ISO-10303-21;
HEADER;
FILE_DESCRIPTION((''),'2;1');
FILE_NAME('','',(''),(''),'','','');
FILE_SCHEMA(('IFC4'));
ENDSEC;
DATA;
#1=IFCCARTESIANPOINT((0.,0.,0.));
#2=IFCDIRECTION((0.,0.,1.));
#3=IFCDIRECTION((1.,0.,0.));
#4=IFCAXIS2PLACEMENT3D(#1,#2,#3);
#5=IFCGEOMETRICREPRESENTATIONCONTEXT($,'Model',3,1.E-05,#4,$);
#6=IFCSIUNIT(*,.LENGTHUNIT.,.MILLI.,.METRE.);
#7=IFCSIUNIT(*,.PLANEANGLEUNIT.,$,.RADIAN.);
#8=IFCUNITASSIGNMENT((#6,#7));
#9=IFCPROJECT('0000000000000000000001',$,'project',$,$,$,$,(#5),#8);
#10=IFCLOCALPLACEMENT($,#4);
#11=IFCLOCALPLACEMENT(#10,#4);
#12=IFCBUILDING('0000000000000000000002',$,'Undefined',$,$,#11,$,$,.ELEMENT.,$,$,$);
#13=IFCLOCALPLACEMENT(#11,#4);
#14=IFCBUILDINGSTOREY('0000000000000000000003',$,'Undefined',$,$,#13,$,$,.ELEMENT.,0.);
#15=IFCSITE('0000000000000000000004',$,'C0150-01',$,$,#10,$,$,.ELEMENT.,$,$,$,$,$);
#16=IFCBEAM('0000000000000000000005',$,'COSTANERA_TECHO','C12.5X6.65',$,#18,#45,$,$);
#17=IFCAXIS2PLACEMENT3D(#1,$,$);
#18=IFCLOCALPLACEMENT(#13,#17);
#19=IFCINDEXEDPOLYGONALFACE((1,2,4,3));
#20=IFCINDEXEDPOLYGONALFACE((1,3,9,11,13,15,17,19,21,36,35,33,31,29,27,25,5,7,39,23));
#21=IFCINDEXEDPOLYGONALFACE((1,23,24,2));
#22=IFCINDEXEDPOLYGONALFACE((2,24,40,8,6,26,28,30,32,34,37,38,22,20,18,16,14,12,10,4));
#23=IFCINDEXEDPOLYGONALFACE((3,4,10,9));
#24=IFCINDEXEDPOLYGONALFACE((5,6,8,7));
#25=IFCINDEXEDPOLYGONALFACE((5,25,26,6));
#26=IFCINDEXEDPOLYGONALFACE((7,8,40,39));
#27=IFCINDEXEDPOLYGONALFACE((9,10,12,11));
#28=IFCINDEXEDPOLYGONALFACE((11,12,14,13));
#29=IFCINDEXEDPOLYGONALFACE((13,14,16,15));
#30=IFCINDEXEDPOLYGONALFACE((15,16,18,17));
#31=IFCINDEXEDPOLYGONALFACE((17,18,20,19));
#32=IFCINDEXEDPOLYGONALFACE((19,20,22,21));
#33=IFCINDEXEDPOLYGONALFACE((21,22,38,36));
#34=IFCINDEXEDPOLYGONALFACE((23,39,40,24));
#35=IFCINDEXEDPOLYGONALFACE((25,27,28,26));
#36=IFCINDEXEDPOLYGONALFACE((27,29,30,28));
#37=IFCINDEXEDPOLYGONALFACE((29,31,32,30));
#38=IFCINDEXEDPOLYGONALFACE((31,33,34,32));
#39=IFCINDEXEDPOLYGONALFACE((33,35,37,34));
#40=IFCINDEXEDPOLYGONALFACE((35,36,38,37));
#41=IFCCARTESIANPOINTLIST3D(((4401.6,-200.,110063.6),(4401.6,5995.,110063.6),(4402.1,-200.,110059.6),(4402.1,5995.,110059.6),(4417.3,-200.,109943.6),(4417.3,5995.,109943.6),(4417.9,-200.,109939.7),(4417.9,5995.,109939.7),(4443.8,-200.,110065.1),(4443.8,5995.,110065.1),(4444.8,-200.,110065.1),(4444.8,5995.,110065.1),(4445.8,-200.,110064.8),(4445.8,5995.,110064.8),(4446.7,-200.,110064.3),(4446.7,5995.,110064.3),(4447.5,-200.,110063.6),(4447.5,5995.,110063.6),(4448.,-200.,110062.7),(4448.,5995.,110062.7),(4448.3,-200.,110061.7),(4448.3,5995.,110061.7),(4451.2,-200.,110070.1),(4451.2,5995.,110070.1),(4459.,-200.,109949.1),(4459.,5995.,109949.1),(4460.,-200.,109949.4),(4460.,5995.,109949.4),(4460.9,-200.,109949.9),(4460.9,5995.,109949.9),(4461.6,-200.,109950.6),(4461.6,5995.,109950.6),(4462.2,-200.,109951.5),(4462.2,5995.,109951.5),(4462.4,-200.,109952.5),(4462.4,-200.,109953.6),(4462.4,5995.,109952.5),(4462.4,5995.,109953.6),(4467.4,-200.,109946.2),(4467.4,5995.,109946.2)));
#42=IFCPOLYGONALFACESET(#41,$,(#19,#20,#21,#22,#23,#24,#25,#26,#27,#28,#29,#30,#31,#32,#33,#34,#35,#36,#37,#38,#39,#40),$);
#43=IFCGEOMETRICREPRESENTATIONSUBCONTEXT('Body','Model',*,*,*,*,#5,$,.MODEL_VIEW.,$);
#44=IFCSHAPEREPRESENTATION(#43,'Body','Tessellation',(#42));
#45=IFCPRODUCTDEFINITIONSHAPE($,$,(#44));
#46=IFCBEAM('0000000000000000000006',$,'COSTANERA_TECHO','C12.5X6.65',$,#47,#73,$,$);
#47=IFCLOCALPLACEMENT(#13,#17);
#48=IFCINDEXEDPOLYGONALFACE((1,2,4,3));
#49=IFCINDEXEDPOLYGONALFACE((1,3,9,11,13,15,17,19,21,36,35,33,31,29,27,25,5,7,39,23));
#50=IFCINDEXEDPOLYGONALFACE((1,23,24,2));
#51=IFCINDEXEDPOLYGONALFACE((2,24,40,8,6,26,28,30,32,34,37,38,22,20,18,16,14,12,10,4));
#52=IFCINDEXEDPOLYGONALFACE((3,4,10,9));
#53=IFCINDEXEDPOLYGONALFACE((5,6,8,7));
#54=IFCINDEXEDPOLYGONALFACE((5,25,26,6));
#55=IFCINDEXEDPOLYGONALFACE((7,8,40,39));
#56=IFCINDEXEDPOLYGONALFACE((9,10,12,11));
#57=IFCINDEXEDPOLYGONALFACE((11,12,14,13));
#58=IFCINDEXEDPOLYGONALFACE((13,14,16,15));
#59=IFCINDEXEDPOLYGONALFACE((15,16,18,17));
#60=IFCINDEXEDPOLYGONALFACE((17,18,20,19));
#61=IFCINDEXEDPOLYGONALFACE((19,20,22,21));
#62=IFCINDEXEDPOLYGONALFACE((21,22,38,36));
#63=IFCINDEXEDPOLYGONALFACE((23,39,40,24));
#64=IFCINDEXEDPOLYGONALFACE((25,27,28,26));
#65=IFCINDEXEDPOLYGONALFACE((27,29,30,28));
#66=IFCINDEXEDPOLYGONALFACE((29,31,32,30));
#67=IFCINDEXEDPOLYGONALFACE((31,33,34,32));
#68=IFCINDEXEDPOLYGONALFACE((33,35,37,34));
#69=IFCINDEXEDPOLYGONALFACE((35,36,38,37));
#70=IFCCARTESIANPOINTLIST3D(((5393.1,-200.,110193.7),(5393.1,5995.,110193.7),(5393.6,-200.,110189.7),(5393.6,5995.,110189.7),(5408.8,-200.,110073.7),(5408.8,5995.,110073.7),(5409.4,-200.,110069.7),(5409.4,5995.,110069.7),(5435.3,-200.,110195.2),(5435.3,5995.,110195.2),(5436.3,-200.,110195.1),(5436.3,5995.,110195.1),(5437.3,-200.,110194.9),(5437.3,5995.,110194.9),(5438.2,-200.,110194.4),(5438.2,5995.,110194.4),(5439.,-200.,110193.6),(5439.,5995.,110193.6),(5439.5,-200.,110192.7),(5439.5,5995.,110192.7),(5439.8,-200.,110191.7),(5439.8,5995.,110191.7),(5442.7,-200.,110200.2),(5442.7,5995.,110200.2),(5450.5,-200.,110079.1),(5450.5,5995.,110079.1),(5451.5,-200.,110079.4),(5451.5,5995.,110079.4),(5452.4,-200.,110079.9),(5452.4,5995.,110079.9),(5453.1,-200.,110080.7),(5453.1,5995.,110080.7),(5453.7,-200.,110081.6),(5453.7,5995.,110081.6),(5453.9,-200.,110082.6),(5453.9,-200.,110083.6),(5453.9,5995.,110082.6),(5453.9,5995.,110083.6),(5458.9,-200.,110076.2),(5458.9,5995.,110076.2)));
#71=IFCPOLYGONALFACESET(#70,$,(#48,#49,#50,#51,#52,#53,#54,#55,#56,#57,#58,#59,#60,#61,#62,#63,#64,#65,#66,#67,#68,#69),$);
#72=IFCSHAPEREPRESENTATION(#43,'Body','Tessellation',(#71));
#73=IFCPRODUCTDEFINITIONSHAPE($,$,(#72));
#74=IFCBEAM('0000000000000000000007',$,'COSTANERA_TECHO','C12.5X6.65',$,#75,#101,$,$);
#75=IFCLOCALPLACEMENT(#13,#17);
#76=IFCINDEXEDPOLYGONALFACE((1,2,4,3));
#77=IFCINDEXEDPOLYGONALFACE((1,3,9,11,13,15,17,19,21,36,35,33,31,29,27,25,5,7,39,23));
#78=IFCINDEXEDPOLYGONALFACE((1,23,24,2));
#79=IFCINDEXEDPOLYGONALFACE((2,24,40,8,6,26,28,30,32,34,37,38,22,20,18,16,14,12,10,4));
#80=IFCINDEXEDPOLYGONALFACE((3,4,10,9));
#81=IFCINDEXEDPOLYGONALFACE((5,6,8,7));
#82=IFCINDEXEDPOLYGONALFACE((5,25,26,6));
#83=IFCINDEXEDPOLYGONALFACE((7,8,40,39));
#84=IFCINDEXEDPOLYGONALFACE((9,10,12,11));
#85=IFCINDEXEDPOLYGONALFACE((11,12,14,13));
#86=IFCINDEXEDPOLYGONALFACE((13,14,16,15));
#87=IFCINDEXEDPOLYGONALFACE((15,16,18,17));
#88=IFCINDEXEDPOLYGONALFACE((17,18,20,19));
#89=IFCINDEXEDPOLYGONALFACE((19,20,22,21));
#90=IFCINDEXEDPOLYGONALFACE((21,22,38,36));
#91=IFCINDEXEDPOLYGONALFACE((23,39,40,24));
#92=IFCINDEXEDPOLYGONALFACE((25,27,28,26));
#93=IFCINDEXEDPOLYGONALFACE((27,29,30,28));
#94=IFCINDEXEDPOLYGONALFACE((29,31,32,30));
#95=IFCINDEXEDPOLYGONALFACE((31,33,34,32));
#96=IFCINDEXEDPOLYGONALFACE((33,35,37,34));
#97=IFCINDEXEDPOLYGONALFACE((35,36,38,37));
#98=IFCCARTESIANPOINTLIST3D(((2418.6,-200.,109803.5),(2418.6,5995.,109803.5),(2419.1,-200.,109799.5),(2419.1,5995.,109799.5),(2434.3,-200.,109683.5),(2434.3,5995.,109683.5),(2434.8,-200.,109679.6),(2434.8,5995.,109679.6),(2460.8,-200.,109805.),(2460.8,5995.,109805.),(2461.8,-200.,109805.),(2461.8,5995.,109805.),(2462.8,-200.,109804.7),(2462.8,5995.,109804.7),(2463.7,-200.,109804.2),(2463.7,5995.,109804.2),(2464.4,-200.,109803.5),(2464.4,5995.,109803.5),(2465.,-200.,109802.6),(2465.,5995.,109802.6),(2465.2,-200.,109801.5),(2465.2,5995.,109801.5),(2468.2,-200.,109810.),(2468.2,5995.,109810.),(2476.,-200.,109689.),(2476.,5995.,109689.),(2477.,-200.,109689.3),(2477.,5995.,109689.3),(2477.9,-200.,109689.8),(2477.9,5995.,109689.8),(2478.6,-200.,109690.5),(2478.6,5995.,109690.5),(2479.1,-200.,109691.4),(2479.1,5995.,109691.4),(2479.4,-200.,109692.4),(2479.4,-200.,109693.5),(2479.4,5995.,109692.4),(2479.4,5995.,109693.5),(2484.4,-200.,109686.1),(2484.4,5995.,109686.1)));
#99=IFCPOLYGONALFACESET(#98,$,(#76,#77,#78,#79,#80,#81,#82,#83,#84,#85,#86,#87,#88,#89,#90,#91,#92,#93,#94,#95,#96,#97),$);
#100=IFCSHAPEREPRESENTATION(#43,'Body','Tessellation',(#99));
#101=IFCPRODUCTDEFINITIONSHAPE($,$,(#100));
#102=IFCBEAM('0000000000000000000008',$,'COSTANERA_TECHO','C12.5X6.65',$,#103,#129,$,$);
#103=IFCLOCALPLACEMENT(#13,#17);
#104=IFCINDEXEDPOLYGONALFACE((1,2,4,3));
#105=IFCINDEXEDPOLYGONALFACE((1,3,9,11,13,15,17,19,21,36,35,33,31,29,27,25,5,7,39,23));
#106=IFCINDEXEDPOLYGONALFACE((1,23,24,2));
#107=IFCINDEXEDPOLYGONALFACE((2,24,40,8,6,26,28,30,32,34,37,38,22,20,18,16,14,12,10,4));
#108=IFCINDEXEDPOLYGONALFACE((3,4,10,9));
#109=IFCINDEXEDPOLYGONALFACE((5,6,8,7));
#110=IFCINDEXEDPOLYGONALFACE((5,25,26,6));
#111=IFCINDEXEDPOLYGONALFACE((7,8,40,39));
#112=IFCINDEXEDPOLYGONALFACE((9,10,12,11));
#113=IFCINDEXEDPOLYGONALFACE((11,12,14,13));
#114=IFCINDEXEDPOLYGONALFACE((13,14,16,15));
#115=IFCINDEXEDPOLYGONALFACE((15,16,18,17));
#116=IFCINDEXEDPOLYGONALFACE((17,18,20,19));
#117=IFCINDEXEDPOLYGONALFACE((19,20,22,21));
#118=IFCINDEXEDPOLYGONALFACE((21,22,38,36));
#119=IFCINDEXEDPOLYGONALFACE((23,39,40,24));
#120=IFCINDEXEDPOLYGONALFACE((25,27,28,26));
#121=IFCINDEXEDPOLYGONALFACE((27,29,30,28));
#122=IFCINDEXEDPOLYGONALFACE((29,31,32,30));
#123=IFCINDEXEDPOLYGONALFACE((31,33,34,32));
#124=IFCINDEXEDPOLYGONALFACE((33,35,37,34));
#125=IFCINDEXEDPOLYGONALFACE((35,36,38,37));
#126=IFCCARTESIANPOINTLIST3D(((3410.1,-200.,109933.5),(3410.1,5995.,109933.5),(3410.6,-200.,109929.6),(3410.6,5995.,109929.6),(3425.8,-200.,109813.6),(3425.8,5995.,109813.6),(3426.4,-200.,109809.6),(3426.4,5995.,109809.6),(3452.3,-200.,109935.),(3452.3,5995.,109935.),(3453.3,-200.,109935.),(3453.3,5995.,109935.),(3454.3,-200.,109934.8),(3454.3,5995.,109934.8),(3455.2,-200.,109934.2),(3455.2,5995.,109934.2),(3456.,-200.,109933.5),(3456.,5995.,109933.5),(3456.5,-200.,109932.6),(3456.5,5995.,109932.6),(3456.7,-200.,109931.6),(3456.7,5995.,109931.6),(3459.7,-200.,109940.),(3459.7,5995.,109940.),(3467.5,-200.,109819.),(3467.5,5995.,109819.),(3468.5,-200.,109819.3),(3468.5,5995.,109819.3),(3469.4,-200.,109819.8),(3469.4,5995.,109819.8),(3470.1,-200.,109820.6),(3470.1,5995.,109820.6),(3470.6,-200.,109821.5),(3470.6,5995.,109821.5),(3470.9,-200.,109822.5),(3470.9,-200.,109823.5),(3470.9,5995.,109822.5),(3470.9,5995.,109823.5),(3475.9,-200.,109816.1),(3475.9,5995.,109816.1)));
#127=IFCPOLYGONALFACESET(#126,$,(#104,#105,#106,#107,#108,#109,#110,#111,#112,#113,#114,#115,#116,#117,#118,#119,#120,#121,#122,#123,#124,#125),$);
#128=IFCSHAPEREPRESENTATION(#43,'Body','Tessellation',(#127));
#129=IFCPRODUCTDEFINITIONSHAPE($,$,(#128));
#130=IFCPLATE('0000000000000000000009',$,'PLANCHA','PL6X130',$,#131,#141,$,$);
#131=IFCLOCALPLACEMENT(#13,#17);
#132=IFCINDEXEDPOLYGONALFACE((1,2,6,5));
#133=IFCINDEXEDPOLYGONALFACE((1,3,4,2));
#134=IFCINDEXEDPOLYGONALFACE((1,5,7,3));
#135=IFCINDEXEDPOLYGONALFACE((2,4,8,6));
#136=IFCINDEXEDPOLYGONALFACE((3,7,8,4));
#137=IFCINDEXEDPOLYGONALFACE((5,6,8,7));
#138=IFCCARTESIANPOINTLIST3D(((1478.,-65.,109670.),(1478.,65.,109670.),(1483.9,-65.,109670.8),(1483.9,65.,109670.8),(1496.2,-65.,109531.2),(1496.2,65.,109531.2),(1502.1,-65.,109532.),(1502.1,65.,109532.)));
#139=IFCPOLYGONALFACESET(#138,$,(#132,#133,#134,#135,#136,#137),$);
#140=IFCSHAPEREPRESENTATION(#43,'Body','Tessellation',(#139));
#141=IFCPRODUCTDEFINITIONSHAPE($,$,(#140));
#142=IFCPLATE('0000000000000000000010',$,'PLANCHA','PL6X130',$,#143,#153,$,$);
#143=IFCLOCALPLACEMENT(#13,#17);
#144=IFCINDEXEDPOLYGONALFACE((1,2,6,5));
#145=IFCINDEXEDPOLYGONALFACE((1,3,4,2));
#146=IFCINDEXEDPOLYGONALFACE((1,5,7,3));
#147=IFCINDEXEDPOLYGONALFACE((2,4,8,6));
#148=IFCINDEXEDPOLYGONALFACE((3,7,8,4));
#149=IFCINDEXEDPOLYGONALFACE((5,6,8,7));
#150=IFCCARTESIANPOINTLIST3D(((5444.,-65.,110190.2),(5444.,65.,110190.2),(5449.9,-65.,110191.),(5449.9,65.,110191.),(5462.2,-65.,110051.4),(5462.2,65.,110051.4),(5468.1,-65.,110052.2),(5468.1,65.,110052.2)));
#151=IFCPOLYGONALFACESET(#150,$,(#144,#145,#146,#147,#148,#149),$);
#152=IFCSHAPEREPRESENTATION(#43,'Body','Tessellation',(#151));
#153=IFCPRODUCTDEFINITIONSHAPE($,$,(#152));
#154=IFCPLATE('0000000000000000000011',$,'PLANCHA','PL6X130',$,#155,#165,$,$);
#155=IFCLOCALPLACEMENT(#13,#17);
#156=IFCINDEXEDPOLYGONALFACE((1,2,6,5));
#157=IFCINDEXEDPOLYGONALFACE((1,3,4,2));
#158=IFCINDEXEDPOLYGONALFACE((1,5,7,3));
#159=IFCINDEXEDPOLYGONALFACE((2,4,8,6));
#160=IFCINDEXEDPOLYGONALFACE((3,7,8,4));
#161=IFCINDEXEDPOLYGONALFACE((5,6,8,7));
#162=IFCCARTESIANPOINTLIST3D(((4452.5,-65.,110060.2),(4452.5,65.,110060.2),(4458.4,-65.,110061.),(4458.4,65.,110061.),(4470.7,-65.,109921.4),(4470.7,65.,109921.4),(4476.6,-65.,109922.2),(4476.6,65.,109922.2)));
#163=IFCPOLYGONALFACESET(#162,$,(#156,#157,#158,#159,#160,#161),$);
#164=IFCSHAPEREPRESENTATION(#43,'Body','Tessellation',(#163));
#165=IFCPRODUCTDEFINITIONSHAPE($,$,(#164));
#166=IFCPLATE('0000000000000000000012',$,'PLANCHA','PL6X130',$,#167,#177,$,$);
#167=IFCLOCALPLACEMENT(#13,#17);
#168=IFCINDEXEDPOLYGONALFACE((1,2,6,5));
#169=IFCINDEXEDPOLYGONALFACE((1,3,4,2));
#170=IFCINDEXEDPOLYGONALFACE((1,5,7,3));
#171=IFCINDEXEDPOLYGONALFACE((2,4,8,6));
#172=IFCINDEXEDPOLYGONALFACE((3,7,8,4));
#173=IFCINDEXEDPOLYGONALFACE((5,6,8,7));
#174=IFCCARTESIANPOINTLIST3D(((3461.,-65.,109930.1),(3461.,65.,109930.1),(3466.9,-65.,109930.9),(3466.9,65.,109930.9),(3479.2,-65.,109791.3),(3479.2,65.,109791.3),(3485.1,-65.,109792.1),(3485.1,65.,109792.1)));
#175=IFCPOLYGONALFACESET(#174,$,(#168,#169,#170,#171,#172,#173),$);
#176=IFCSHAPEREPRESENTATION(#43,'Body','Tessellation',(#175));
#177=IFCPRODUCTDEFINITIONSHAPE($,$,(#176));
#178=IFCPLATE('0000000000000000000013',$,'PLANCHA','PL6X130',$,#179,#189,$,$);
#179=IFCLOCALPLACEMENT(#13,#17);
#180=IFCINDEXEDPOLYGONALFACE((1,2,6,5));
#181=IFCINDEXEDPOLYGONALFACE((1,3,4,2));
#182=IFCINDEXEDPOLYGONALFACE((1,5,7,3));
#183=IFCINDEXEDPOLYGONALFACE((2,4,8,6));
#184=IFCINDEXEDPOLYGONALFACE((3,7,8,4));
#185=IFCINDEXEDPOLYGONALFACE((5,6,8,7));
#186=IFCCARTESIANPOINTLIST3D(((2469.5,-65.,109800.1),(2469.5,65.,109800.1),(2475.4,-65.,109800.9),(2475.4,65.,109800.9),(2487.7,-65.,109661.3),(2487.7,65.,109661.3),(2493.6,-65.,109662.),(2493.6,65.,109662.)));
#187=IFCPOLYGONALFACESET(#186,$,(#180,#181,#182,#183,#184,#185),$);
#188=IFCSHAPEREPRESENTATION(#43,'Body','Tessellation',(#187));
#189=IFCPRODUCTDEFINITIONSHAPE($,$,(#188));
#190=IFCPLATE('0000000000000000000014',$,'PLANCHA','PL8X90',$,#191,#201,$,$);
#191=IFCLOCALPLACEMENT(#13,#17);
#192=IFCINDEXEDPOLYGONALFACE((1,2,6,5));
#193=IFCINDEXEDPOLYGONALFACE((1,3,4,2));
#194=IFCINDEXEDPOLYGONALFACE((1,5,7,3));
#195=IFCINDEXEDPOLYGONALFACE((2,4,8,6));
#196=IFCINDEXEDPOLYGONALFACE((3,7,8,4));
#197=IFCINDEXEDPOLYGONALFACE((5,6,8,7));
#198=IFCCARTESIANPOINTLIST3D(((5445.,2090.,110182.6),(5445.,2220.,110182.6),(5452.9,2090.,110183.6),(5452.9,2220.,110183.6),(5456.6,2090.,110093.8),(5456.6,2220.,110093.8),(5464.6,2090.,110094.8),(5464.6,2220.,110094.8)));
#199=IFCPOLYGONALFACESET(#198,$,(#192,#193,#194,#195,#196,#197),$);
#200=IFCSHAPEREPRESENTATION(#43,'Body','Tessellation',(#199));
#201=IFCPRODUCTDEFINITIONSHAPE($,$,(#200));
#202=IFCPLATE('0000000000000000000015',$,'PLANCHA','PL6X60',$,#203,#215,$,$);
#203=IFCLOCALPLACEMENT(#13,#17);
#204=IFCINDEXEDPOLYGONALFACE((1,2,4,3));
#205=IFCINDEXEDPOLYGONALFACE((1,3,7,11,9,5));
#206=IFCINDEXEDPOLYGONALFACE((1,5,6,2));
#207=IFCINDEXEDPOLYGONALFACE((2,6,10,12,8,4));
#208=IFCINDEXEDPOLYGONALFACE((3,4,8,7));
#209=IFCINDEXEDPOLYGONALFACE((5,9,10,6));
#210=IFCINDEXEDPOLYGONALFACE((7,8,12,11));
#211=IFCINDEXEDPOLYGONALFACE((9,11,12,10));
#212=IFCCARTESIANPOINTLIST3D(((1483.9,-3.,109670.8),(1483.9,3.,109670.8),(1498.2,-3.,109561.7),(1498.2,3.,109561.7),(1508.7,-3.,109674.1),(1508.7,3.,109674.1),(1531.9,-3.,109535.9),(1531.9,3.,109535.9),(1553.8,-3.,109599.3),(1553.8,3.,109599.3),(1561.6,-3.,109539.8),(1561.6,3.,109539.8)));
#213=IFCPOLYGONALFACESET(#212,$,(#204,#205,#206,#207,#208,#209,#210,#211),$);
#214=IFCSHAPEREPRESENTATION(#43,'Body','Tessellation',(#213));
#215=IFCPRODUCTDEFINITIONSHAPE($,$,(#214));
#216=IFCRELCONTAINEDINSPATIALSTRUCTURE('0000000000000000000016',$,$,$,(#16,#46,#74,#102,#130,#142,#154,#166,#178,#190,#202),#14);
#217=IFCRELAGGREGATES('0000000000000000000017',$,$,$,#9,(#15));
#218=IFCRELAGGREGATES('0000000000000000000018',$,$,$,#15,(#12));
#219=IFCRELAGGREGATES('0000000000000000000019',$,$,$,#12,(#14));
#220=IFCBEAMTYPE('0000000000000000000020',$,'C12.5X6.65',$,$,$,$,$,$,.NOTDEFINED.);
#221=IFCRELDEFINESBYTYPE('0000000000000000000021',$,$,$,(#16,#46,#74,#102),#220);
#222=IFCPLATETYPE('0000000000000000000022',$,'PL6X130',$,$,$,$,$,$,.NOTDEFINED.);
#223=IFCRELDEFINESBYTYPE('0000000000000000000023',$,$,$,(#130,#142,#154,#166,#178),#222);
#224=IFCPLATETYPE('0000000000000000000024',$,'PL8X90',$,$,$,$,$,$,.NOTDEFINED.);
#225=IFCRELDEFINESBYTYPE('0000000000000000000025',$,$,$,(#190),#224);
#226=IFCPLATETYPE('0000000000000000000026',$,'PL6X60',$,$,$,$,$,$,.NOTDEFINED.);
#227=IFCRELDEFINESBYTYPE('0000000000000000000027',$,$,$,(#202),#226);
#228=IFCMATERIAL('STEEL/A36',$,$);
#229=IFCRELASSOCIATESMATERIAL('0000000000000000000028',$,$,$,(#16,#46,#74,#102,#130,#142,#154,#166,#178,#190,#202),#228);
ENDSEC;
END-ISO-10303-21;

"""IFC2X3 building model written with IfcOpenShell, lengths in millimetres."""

from ifc_helpers import new_model, si_unit, frame, origin_with_axes, origin_2d_with_axis, place, context, subcontext, project, spatial, polyline, u_section, outline, extrude, material, type_object, element, save


model = new_model("IFC2X3")

# Units and contexts
model_context = context("Model", 3, precision=1e-05, world=origin_with_axes())
body_context = subcontext(model_context, "Body", "Model", "MODEL_VIEW")
ifc_project = project(units=[si_unit("LENGTHUNIT", "METRE", prefix="MILLI"), si_unit("PLANEANGLEUNIT", "RADIAN")], contexts=[model_context])

# Site, building, storey
site_placement = place(None, origin_with_axes())
site = spatial("IfcSite", under=ifc_project, at=site_placement, Name="C0150-01", CompositionType="ELEMENT")
building_placement = place(site_placement, origin_with_axes())
building = spatial("IfcBuilding", under=site, at=building_placement, Name="Undefined", CompositionType="ELEMENT")
storey_placement = place(building_placement, origin_with_axes())
storey = spatial("IfcBuildingStorey", under=building, at=storey_placement, Name="Undefined", CompositionType="ELEMENT", Elevation=0.0)

# Beams
ifc_material_1 = material(Name="STEEL/A36")
beam_type_1 = type_object("IfcBeamType", Name="C12.5X6.65", PredefinedType="NOTDEFINED")
for number, where, z_axis, x_axis, name in (
    (1, (4434.5, -200.0, 110004.9), (0.130054, 0.0, -0.991507), (0.0, 1.0, 0.0), "COSTANERA_TECHO"),
    (2, (5426.0, -200.0, 110134.9), (0.130054, 0.0, -0.991507), (0.0, 1.0, 0.0), "COSTANERA_TECHO"),
    (3, (2451.5, -200.0, 109744.8), (0.130054, 0.0, -0.991507), (0.0, 1.0, 0.0), "COSTANERA_TECHO"),
    (4, (3443.0, -200.0, 109874.8), (0.130054, 0.0, -0.991507), (0.0, 1.0, 0.0), "COSTANERA_TECHO"),
):
    element("IfcBeam", number, at=place(storey_placement, frame(where, z_axis=z_axis, x_axis=x_axis)), inside=storey, type_object=beam_type_1, material=ifc_material_1, Name=name, Description="C12.5X6.65", context=body_context, shape_type="SweptSolid", body=[
        extrude(u_section(Depth=125.0, FlangeWidth=50.0, WebThickness=4.0, FlangeThickness=4.0, FilletRadius=4.0, at=origin_2d_with_axis()), frame((6195.0, 0.0, 0.0), z_axis=(-1.0, 0.0, 0.0), x_axis=(0.0, -1.0, 0.0)), (0.0, 0.0, 1.0), 6195.0),
    ])

# Plates
plate_type_1 = type_object("IfcPlateType", Name="PL6X130", PredefinedType="NOTDEFINED")
for number, where, z_axis, x_axis, name in (
    (5, (1499.1, -65.0, 109531.6), (0.991507, 0.0, 0.130054), (0.0, 1.0, 0.0), "PLANCHA"),
    (6, (5465.2, -65.0, 110051.8), (0.991507, 0.0, 0.130054), (0.0, 1.0, 0.0), "PLANCHA"),
    (7, (4473.7, -65.0, 109921.8), (0.991507, 0.0, 0.130054), (0.0, 1.0, 0.0), "PLANCHA"),
    (8, (3482.2, -65.0, 109791.7), (0.991507, 0.0, 0.130054), (0.0, 1.0, 0.0), "PLANCHA"),
    (9, (2490.6, -65.0, 109661.7), (0.991507, 0.0, 0.130054), (0.0, 1.0, 0.0), "PLANCHA"),
):
    element("IfcPlate", number, at=place(storey_placement, frame(where, z_axis=z_axis, x_axis=x_axis)), inside=storey, type_object=plate_type_1, material=ifc_material_1, Name=name, Description="PL6X130", context=body_context, shape_type="SweptSolid", body=[
        extrude(outline(polyline([(0.0, 0.0), (130.0, 0.0), (130.0, 140.0), (0.0, 140.0), (0.0, 0.0)])), frame((0.0, 0.0, -3.0), z_axis=(0.0, 0.0, 1.0), x_axis=(1.0, 0.0, 0.0)), (0.0, 0.0, 1.0), 6.0),
    ])
plate_type_2 = type_object("IfcPlateType", Name="PL8X90", PredefinedType="NOTDEFINED")
plate_1_placement = place(storey_placement, frame((5449.0, 2090.0, 110183.1), z_axis=(-0.991507, 0.0, -0.130054), x_axis=(0.0, 1.0, 0.0)))
element("IfcPlate", 10, at=plate_1_placement, inside=storey, type_object=plate_type_2, material=ifc_material_1, Name="PLANCHA", Description="PL8X90", context=body_context, shape_type="SweptSolid", body=[
    extrude(outline(polyline([(0.0, 0.0), (130.0, 0.0), (130.0, 89.6), (0.0, 89.6), (0.0, 0.0)])), frame((0.0, 0.0, -4.0), z_axis=(0.0, 0.0, 1.0), x_axis=(1.0, 0.0, 0.0)), (0.0, 0.0, 1.0), 8.0),
])
plate_type_3 = type_object("IfcPlateType", Name="PL6X60", PredefinedType="NOTDEFINED")
for number, where, z_axis, x_axis, name in (
    (11, (1508.7, 0.0, 109674.1), (0.0, -1.0, 0.0), (-0.991507, 0.0, -0.130054), "PLANCHA"),
):
    element("IfcPlate", number, at=place(storey_placement, frame(where, z_axis=z_axis, x_axis=x_axis)), inside=storey, type_object=plate_type_3, material=ifc_material_1, Name=name, Description="PL6X60", context=body_context, shape_type="SweptSolid", body=[
        extrude(outline(polyline([(0.0, 0.0), (25.0, 0.0), (25.0, 110.0), (-5.0, 140.0), (-35.0, 140.0), (-35.0, 80.0), (0.0, 0.0)])), frame((0.0, 0.0, -3.0), z_axis=(0.0, 0.0, 1.0), x_axis=(1.0, 0.0, 0.0)), (0.0, 0.0, 1.0), 6.0),
    ])

save(model, "model.ifc")
